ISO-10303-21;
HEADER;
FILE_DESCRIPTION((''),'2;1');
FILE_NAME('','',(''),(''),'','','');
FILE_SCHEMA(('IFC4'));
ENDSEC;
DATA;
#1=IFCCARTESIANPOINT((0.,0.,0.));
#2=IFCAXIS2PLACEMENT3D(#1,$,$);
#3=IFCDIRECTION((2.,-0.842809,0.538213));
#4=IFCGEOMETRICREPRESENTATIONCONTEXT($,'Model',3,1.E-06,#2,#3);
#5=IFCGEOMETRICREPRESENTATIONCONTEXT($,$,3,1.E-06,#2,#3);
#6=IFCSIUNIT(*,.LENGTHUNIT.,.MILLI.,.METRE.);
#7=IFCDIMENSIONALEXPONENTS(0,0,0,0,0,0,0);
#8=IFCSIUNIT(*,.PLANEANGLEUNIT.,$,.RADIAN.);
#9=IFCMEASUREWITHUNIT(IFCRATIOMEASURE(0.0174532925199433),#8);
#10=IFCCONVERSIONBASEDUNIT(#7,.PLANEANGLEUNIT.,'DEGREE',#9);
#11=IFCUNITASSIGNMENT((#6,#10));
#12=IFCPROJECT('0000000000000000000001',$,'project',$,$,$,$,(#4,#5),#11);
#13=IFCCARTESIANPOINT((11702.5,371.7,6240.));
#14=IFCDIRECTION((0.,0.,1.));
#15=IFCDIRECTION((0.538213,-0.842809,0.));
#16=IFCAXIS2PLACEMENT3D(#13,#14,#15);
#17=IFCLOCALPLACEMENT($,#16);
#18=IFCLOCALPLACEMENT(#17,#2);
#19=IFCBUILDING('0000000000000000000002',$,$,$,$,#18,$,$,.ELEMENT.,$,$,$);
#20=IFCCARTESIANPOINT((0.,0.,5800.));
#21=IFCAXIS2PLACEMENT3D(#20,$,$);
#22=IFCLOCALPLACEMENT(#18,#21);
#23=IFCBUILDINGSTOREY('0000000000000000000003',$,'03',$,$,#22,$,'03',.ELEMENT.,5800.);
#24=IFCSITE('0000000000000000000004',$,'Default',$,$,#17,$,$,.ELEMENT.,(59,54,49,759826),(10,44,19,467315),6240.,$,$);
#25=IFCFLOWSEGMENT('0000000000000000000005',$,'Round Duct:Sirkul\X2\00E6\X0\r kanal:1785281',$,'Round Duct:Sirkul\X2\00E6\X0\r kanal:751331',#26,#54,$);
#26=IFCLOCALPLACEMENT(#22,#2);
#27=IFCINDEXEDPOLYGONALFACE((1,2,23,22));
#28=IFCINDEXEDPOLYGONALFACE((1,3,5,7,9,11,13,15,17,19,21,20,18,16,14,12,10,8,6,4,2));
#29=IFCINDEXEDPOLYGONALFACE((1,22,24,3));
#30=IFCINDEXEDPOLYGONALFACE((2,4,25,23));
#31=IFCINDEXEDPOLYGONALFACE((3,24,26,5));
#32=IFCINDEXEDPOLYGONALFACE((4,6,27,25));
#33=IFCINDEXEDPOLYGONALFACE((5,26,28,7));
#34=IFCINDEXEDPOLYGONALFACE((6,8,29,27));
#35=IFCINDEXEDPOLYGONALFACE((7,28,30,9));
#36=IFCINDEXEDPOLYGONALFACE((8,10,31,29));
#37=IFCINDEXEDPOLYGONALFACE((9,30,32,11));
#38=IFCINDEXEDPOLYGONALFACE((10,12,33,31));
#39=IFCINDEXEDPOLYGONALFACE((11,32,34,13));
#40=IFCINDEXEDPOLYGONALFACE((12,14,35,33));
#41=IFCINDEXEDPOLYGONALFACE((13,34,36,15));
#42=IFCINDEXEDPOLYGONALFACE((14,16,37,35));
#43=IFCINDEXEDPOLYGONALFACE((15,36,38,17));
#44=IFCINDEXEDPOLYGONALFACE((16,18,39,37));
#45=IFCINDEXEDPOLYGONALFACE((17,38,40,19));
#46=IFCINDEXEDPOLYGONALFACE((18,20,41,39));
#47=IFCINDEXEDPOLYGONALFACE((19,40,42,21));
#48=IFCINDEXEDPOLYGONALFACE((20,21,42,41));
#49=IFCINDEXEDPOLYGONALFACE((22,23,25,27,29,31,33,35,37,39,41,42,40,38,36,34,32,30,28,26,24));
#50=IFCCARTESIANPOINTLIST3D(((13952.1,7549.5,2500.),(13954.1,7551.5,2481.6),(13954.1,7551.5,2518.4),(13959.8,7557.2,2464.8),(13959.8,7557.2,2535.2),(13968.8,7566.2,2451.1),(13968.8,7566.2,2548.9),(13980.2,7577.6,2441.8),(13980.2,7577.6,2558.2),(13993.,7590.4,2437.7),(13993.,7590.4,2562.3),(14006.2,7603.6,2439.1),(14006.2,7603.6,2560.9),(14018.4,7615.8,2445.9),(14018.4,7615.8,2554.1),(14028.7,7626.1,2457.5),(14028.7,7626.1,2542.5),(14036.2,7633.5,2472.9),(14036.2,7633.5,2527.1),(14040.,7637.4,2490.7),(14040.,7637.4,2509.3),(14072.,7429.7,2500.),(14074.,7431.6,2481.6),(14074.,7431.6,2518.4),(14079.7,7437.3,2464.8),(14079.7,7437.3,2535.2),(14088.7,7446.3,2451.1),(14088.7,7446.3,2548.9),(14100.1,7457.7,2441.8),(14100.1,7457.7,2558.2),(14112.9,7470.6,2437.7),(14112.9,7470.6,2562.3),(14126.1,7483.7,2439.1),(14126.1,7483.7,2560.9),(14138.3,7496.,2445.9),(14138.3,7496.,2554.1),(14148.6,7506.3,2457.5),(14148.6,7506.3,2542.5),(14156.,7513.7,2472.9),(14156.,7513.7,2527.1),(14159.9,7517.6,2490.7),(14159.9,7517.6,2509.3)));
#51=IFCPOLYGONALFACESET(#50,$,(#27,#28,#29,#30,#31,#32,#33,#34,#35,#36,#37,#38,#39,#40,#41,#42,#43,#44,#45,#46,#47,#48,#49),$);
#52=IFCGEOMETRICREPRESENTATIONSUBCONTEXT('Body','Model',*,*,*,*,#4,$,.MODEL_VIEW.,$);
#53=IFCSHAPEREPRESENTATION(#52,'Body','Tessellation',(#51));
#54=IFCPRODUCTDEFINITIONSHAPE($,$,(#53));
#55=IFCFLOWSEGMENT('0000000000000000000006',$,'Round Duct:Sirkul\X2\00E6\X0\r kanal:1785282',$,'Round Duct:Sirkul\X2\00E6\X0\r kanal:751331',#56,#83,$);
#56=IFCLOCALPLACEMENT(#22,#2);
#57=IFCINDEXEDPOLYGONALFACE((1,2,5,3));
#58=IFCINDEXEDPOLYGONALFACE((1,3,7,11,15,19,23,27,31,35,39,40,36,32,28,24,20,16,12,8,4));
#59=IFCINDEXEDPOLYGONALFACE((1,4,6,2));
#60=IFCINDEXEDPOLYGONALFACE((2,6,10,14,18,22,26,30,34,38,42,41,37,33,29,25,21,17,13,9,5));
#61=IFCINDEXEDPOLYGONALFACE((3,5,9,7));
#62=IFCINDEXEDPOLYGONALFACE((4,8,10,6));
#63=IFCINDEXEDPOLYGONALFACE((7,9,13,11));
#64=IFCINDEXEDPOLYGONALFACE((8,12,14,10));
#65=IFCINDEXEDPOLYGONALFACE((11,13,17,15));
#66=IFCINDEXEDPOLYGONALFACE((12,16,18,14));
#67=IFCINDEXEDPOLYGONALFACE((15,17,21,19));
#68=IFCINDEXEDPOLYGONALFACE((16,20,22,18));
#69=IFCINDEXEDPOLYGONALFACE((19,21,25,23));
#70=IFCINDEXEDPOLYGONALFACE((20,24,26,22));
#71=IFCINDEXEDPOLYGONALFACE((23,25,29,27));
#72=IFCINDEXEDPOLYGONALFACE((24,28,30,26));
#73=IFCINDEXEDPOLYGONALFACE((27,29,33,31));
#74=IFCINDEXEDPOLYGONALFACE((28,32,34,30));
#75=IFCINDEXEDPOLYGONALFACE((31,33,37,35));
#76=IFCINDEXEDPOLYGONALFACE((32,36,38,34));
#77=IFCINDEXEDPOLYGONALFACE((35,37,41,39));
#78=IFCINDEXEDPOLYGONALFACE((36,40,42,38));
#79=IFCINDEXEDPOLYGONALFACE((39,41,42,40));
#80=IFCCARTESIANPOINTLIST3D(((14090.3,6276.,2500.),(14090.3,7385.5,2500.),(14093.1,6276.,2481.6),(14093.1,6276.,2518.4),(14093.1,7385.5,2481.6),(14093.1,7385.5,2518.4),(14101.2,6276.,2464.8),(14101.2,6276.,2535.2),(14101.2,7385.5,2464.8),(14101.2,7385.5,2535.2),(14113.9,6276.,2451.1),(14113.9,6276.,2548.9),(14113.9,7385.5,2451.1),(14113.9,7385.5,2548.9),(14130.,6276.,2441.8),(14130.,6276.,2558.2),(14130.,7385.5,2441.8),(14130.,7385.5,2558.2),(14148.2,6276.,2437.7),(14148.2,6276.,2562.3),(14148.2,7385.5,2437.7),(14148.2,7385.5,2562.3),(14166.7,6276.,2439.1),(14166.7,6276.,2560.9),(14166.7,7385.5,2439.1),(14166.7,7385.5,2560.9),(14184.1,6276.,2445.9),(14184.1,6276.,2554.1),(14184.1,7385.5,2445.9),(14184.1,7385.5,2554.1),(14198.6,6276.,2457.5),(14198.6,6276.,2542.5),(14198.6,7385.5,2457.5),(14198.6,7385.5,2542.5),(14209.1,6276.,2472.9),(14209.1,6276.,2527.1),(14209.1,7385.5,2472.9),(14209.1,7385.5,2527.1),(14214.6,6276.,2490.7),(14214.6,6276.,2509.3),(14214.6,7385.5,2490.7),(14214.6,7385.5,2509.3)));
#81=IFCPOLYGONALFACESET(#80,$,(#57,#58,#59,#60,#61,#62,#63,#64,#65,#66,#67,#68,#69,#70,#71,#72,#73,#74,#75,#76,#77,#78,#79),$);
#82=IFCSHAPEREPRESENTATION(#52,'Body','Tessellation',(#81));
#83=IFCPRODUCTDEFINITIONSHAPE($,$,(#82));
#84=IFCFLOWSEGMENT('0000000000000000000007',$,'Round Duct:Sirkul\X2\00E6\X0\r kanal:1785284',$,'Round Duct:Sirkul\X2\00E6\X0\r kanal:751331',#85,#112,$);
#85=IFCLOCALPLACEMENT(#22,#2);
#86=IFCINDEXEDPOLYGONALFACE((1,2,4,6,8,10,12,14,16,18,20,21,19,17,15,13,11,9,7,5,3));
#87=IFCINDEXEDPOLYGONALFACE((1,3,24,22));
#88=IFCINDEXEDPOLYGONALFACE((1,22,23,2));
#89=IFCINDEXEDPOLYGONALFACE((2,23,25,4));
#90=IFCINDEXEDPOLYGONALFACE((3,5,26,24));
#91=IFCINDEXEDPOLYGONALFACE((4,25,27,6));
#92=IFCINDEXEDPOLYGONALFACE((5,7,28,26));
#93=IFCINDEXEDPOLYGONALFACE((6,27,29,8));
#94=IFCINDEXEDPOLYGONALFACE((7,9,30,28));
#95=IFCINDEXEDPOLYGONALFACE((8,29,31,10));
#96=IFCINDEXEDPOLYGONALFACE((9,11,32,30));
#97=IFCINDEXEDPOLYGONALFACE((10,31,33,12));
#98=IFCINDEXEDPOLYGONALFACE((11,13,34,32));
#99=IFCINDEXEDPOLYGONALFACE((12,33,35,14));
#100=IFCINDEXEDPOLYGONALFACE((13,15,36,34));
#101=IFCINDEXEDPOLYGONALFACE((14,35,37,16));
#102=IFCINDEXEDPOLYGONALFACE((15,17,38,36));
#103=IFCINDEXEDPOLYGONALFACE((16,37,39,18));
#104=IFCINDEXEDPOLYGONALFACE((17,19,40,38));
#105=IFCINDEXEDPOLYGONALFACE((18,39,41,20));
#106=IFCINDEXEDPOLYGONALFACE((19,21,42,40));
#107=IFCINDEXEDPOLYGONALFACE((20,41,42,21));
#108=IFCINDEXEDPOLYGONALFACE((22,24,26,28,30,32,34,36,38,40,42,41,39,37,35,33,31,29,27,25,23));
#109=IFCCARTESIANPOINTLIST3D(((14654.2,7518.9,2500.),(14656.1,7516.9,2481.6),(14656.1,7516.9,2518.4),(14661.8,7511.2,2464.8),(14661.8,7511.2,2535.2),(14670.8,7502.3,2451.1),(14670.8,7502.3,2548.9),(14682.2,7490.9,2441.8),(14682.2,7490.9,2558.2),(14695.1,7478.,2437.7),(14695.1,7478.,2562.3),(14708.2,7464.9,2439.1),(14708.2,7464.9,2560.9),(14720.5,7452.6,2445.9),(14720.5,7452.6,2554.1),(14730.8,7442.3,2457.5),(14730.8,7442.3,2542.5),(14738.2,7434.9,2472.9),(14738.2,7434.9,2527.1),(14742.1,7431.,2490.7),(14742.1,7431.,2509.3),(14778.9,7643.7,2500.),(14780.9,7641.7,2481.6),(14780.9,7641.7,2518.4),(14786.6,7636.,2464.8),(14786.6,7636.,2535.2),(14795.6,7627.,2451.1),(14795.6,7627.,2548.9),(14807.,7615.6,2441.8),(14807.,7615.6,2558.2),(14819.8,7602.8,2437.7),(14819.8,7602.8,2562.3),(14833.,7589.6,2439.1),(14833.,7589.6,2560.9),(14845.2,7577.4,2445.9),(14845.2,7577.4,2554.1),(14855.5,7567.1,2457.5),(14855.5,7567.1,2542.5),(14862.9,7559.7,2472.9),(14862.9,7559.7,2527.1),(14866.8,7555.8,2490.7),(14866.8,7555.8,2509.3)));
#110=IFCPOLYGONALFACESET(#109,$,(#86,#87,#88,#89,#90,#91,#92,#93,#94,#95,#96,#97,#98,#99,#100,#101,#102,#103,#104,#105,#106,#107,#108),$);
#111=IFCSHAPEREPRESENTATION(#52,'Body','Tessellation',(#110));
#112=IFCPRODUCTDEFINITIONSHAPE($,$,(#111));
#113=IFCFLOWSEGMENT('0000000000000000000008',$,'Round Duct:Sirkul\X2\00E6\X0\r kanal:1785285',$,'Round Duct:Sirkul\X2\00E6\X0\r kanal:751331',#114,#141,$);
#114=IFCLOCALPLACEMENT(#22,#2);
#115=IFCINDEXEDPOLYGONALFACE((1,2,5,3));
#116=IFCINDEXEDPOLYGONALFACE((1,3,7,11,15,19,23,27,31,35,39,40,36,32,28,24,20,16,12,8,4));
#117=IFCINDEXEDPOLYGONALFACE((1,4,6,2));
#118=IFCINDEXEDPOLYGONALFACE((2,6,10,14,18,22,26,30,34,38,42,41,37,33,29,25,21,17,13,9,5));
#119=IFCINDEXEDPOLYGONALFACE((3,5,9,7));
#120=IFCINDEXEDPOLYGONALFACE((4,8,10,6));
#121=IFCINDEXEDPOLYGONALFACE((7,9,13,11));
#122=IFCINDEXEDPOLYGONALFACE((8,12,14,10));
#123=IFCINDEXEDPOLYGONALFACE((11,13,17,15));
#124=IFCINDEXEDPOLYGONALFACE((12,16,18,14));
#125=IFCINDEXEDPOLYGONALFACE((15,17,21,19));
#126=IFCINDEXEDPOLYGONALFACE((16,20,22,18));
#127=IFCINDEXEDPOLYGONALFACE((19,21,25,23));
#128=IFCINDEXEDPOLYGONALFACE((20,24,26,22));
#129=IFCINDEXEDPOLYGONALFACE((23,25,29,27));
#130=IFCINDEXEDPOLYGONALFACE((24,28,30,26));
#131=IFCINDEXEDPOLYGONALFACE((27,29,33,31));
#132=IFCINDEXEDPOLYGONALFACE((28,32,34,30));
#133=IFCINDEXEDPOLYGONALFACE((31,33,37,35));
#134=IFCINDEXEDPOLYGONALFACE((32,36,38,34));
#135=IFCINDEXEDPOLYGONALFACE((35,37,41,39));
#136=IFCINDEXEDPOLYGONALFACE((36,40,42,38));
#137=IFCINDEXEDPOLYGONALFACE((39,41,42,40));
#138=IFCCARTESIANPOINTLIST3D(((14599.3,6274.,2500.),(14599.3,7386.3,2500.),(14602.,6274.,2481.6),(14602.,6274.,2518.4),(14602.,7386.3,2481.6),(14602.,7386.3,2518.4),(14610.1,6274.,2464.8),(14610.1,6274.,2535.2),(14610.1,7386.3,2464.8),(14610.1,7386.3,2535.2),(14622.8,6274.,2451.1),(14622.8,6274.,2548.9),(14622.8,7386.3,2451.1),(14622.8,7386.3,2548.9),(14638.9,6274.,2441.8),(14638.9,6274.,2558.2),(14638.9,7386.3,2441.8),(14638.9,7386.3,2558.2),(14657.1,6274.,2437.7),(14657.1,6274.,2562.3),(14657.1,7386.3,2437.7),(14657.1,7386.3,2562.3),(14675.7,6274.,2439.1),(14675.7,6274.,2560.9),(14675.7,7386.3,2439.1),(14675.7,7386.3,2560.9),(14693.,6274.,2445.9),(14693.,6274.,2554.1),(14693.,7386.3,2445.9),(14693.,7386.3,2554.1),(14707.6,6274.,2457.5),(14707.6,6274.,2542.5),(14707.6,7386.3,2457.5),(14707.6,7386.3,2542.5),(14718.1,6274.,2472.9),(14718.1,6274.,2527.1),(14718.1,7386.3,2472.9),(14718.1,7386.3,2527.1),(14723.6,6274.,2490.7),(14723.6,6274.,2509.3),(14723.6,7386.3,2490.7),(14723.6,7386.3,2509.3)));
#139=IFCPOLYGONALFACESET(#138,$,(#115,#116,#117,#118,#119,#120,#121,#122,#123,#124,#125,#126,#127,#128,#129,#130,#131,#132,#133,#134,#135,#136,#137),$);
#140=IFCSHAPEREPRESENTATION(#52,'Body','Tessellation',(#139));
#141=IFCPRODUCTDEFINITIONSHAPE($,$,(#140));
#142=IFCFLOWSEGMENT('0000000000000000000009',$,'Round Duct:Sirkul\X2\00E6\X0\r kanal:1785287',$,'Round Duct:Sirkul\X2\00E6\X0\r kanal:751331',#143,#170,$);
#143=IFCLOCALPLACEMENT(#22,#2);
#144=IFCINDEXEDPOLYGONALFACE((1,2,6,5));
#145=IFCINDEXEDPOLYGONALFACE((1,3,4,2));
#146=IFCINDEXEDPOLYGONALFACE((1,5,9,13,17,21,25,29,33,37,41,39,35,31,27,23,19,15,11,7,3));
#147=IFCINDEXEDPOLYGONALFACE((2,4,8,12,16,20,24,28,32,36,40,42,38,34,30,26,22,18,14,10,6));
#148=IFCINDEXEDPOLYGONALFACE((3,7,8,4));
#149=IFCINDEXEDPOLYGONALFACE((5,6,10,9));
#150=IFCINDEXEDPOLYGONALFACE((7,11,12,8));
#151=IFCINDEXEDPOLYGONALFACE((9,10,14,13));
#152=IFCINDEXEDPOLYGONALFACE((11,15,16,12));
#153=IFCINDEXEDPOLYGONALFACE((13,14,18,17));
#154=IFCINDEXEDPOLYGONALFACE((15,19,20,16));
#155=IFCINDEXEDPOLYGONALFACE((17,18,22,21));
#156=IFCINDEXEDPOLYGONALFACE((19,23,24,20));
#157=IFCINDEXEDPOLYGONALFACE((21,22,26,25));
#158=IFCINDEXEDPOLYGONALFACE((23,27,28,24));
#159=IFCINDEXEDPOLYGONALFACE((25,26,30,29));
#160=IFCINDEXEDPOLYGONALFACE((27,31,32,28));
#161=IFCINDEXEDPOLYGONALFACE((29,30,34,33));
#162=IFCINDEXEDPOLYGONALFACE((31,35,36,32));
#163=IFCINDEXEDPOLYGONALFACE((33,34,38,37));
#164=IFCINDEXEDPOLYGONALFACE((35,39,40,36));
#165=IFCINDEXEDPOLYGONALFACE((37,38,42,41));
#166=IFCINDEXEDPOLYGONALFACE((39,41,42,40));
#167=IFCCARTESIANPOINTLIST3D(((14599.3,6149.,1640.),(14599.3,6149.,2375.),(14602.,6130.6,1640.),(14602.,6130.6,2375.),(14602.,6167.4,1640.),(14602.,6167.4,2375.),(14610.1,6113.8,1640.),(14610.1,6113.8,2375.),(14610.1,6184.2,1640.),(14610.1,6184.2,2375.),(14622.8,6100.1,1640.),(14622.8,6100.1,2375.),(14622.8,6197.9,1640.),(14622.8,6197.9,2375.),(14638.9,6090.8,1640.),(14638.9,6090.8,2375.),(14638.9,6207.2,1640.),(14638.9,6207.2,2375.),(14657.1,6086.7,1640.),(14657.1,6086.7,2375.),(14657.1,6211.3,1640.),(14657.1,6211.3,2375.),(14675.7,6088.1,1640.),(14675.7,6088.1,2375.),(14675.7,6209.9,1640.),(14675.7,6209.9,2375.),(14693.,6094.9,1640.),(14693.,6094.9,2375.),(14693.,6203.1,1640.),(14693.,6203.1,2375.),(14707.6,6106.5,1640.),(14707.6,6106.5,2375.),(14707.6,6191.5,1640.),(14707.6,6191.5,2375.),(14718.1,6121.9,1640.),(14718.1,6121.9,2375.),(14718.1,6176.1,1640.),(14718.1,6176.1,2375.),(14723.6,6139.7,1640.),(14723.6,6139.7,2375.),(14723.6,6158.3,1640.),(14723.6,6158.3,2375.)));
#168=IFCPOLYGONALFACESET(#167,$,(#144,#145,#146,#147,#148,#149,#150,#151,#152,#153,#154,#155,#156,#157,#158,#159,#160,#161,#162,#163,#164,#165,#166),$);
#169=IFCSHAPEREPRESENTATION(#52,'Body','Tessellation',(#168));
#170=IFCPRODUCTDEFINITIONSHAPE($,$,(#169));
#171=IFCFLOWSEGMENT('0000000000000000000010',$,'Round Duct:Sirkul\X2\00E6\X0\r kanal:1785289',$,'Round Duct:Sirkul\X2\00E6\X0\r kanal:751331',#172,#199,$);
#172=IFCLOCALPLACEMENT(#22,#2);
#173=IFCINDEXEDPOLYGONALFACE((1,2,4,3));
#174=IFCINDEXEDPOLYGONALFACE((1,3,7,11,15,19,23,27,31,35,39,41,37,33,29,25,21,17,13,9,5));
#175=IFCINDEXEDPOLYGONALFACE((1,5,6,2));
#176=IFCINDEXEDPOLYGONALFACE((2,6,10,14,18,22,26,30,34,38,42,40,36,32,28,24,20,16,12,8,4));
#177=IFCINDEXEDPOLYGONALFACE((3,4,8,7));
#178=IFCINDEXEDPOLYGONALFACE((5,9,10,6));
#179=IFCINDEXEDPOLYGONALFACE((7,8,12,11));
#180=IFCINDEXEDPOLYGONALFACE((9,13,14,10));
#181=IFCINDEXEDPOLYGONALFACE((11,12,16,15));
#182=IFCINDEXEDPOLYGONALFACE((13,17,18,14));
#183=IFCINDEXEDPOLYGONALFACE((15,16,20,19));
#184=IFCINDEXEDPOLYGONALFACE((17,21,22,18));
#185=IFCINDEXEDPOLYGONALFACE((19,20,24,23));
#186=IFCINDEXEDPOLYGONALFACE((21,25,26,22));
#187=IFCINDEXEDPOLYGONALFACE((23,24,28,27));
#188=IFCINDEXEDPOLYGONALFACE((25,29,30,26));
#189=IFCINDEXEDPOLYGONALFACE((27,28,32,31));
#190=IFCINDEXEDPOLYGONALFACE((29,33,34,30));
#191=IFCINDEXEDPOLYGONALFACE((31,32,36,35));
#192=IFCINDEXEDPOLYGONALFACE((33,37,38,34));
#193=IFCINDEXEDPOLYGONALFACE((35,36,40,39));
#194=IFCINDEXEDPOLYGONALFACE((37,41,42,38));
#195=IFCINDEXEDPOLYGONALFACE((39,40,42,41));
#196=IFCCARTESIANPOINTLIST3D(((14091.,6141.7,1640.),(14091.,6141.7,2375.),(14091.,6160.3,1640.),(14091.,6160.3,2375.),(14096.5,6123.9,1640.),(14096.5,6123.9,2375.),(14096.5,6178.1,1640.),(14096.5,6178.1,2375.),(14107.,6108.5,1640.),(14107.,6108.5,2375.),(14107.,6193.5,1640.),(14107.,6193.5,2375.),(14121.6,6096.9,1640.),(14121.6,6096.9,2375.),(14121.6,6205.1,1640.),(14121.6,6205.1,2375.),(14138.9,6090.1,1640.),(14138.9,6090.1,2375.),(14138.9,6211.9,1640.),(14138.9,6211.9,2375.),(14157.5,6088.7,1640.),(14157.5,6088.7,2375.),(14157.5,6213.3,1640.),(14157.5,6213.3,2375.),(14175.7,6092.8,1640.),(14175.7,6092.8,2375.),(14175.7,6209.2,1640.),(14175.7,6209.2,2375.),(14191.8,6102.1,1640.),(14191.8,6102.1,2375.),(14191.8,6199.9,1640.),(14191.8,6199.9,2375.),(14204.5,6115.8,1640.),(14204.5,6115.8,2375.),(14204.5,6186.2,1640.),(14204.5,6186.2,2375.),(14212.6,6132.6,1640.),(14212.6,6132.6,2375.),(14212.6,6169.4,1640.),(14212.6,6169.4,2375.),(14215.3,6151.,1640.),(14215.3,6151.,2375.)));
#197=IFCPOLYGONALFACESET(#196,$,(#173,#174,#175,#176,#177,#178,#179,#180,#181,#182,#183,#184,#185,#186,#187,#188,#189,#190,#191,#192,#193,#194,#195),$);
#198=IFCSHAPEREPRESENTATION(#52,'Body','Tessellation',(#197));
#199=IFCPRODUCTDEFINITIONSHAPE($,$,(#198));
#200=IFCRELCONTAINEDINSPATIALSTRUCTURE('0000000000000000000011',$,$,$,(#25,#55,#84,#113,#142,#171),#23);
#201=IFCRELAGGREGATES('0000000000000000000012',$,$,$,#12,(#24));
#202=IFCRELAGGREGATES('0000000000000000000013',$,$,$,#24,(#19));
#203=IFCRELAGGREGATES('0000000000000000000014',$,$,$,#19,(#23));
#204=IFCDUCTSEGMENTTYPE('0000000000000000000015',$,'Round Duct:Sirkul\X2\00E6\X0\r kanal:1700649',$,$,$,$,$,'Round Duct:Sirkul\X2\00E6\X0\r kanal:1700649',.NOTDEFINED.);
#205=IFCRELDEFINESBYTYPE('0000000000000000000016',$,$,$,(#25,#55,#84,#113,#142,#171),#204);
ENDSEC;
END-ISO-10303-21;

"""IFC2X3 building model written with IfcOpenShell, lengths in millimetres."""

from ifc_helpers import new_model, entity, si_unit, converted_unit, direction, frame, frame_2d, origin, origin_2d_with_axis, place, context, subcontext, project, spatial, circle, extrude, type_object, element, save


model = new_model("IFC2X3")

# Units and contexts
model_context = context("Model", 3, precision=1e-06, world=origin(), true_north=direction((2.0, -0.842809, 0.538213)))
context_of_model = context(None, 3, precision=1e-06, world=origin(), true_north=direction((2.0, -0.842809, 0.538213)))
body_context = subcontext(model_context, "Body", "Model", "MODEL_VIEW")
ifc_project = project(units=[si_unit("LENGTHUNIT", "METRE", prefix="MILLI"), converted_unit("PLANEANGLEUNIT", "DEGREE", entity("IfcRatioMeasure", 0.0174532925199433), si_unit("PLANEANGLEUNIT", "RADIAN"), dimensions=[0, 0, 0, 0, 0, 0, 0])], contexts=[model_context, context_of_model])

# Site, building, storey
site_placement = place(None, frame((11702.5, 371.7, 6240.0), z_axis=(0.0, 0.0, 1.0), x_axis=(0.538213, -0.842809, 0.0)))
site = spatial("IfcSite", under=ifc_project, at=site_placement, Name="Default", CompositionType="ELEMENT", RefLatitude=(59, 54, 49, 759826), RefLongitude=(10, 44, 19, 467315), RefElevation=6240.0)
building_placement = place(site_placement, origin())
building = spatial("IfcBuilding", under=site, at=building_placement, CompositionType="ELEMENT")
storey_placement = place(building_placement, frame((0.0, 0.0, 5800.0)))
storey = spatial("IfcBuildingStorey", under=building, at=storey_placement, Name="03", LongName="03", CompositionType="ELEMENT", Elevation=5800.0)

# Flow segments
duct_segment_type = type_object("IfcDuctSegmentType", Name="Round Duct:Sirkulær kanal:1700649", ElementType="Round Duct:Sirkulær kanal:1700649", PredefinedType="NOTDEFINED")
flow_segment_1_placement = place(storey_placement, origin())
element("IfcFlowSegment", 1, at=flow_segment_1_placement, inside=storey, type_object=duct_segment_type, Name="Round Duct:Sirkulær kanal:1785281", ObjectType="Round Duct:Sirkulær kanal:751331", context=body_context, shape_type="SweptSolid", body=[
    extrude(circle(Radius=62.5, at=origin_2d_with_axis()), frame((13996.3, 7593.7, 2500.0), z_axis=(0.707107, -0.707107, 0.0), x_axis=(-0.707107, -0.707107, 0.0)), (0.0, 0.0, 1.0), 169.5),
])
flow_segment_2_placement = place(storey_placement, origin())
element("IfcFlowSegment", 2, at=flow_segment_2_placement, inside=storey, type_object=duct_segment_type, Name="Round Duct:Sirkulær kanal:1785282", ObjectType="Round Duct:Sirkulær kanal:751331", context=body_context, shape_type="SweptSolid", body=[
    extrude(circle(Radius=62.5, at=frame_2d((0.0, 0.0), x_axis=(1.0, 0.0))), frame((14152.8, 6276.0, 2500.0), z_axis=(0.0, 1.0, 0.0), x_axis=(-1.0, 0.0, 0.0)), (0.0, 0.0, 1.0), 1109.5),
])
flow_segment_3_placement = place(storey_placement, origin())
element("IfcFlowSegment", 3, at=flow_segment_3_placement, inside=storey, type_object=duct_segment_type, Name="Round Duct:Sirkulær kanal:1785284", ObjectType="Round Duct:Sirkulær kanal:751331", context=body_context, shape_type="SweptSolid", body=[
    extrude(circle(Radius=62.5, at=origin_2d_with_axis()), frame((14698.4, 7474.7, 2500.0), z_axis=(0.707107, 0.707107, 0.0), x_axis=(-0.707107, 0.707107, 0.0)), (0.0, 0.0, 1.0), 176.4),
])
flow_segment_4_placement = place(storey_placement, origin())
element("IfcFlowSegment", 4, at=flow_segment_4_placement, inside=storey, type_object=duct_segment_type, Name="Round Duct:Sirkulær kanal:1785285", ObjectType="Round Duct:Sirkulær kanal:751331", context=body_context, shape_type="SweptSolid", body=[
    extrude(circle(Radius=62.5, at=origin_2d_with_axis()), frame((14661.8, 6274.0, 2500.0), z_axis=(0.0, 1.0, 0.0), x_axis=(-1.0, 0.0, 0.0)), (0.0, 0.0, 1.0), 1112.3),
])
flow_segment_5_placement = place(storey_placement, origin())
element("IfcFlowSegment", 5, at=flow_segment_5_placement, inside=storey, type_object=duct_segment_type, Name="Round Duct:Sirkulær kanal:1785287", ObjectType="Round Duct:Sirkulær kanal:751331", context=body_context, shape_type="SweptSolid", body=[
    extrude(circle(Radius=62.5, at=origin_2d_with_axis()), frame((14661.8, 6149.0, 1640.0), z_axis=(0.0, 0.0, 1.0), x_axis=(-1.0, 0.0, 0.0)), (0.0, 0.0, 1.0), 735.0),
])
flow_segment_6_placement = place(storey_placement, origin())
element("IfcFlowSegment", 6, at=flow_segment_6_placement, inside=storey, type_object=duct_segment_type, Name="Round Duct:Sirkulær kanal:1785289", ObjectType="Round Duct:Sirkulær kanal:751331", context=body_context, shape_type="SweptSolid", body=[
    extrude(circle(Radius=62.5, at=frame_2d((0.0, 0.0), x_axis=(1.0, 0.0))), frame((14152.8, 6151.0, 1640.0)), (0.0, 0.0, 1.0), 735.0),
])

save(model, "model.ifc")
